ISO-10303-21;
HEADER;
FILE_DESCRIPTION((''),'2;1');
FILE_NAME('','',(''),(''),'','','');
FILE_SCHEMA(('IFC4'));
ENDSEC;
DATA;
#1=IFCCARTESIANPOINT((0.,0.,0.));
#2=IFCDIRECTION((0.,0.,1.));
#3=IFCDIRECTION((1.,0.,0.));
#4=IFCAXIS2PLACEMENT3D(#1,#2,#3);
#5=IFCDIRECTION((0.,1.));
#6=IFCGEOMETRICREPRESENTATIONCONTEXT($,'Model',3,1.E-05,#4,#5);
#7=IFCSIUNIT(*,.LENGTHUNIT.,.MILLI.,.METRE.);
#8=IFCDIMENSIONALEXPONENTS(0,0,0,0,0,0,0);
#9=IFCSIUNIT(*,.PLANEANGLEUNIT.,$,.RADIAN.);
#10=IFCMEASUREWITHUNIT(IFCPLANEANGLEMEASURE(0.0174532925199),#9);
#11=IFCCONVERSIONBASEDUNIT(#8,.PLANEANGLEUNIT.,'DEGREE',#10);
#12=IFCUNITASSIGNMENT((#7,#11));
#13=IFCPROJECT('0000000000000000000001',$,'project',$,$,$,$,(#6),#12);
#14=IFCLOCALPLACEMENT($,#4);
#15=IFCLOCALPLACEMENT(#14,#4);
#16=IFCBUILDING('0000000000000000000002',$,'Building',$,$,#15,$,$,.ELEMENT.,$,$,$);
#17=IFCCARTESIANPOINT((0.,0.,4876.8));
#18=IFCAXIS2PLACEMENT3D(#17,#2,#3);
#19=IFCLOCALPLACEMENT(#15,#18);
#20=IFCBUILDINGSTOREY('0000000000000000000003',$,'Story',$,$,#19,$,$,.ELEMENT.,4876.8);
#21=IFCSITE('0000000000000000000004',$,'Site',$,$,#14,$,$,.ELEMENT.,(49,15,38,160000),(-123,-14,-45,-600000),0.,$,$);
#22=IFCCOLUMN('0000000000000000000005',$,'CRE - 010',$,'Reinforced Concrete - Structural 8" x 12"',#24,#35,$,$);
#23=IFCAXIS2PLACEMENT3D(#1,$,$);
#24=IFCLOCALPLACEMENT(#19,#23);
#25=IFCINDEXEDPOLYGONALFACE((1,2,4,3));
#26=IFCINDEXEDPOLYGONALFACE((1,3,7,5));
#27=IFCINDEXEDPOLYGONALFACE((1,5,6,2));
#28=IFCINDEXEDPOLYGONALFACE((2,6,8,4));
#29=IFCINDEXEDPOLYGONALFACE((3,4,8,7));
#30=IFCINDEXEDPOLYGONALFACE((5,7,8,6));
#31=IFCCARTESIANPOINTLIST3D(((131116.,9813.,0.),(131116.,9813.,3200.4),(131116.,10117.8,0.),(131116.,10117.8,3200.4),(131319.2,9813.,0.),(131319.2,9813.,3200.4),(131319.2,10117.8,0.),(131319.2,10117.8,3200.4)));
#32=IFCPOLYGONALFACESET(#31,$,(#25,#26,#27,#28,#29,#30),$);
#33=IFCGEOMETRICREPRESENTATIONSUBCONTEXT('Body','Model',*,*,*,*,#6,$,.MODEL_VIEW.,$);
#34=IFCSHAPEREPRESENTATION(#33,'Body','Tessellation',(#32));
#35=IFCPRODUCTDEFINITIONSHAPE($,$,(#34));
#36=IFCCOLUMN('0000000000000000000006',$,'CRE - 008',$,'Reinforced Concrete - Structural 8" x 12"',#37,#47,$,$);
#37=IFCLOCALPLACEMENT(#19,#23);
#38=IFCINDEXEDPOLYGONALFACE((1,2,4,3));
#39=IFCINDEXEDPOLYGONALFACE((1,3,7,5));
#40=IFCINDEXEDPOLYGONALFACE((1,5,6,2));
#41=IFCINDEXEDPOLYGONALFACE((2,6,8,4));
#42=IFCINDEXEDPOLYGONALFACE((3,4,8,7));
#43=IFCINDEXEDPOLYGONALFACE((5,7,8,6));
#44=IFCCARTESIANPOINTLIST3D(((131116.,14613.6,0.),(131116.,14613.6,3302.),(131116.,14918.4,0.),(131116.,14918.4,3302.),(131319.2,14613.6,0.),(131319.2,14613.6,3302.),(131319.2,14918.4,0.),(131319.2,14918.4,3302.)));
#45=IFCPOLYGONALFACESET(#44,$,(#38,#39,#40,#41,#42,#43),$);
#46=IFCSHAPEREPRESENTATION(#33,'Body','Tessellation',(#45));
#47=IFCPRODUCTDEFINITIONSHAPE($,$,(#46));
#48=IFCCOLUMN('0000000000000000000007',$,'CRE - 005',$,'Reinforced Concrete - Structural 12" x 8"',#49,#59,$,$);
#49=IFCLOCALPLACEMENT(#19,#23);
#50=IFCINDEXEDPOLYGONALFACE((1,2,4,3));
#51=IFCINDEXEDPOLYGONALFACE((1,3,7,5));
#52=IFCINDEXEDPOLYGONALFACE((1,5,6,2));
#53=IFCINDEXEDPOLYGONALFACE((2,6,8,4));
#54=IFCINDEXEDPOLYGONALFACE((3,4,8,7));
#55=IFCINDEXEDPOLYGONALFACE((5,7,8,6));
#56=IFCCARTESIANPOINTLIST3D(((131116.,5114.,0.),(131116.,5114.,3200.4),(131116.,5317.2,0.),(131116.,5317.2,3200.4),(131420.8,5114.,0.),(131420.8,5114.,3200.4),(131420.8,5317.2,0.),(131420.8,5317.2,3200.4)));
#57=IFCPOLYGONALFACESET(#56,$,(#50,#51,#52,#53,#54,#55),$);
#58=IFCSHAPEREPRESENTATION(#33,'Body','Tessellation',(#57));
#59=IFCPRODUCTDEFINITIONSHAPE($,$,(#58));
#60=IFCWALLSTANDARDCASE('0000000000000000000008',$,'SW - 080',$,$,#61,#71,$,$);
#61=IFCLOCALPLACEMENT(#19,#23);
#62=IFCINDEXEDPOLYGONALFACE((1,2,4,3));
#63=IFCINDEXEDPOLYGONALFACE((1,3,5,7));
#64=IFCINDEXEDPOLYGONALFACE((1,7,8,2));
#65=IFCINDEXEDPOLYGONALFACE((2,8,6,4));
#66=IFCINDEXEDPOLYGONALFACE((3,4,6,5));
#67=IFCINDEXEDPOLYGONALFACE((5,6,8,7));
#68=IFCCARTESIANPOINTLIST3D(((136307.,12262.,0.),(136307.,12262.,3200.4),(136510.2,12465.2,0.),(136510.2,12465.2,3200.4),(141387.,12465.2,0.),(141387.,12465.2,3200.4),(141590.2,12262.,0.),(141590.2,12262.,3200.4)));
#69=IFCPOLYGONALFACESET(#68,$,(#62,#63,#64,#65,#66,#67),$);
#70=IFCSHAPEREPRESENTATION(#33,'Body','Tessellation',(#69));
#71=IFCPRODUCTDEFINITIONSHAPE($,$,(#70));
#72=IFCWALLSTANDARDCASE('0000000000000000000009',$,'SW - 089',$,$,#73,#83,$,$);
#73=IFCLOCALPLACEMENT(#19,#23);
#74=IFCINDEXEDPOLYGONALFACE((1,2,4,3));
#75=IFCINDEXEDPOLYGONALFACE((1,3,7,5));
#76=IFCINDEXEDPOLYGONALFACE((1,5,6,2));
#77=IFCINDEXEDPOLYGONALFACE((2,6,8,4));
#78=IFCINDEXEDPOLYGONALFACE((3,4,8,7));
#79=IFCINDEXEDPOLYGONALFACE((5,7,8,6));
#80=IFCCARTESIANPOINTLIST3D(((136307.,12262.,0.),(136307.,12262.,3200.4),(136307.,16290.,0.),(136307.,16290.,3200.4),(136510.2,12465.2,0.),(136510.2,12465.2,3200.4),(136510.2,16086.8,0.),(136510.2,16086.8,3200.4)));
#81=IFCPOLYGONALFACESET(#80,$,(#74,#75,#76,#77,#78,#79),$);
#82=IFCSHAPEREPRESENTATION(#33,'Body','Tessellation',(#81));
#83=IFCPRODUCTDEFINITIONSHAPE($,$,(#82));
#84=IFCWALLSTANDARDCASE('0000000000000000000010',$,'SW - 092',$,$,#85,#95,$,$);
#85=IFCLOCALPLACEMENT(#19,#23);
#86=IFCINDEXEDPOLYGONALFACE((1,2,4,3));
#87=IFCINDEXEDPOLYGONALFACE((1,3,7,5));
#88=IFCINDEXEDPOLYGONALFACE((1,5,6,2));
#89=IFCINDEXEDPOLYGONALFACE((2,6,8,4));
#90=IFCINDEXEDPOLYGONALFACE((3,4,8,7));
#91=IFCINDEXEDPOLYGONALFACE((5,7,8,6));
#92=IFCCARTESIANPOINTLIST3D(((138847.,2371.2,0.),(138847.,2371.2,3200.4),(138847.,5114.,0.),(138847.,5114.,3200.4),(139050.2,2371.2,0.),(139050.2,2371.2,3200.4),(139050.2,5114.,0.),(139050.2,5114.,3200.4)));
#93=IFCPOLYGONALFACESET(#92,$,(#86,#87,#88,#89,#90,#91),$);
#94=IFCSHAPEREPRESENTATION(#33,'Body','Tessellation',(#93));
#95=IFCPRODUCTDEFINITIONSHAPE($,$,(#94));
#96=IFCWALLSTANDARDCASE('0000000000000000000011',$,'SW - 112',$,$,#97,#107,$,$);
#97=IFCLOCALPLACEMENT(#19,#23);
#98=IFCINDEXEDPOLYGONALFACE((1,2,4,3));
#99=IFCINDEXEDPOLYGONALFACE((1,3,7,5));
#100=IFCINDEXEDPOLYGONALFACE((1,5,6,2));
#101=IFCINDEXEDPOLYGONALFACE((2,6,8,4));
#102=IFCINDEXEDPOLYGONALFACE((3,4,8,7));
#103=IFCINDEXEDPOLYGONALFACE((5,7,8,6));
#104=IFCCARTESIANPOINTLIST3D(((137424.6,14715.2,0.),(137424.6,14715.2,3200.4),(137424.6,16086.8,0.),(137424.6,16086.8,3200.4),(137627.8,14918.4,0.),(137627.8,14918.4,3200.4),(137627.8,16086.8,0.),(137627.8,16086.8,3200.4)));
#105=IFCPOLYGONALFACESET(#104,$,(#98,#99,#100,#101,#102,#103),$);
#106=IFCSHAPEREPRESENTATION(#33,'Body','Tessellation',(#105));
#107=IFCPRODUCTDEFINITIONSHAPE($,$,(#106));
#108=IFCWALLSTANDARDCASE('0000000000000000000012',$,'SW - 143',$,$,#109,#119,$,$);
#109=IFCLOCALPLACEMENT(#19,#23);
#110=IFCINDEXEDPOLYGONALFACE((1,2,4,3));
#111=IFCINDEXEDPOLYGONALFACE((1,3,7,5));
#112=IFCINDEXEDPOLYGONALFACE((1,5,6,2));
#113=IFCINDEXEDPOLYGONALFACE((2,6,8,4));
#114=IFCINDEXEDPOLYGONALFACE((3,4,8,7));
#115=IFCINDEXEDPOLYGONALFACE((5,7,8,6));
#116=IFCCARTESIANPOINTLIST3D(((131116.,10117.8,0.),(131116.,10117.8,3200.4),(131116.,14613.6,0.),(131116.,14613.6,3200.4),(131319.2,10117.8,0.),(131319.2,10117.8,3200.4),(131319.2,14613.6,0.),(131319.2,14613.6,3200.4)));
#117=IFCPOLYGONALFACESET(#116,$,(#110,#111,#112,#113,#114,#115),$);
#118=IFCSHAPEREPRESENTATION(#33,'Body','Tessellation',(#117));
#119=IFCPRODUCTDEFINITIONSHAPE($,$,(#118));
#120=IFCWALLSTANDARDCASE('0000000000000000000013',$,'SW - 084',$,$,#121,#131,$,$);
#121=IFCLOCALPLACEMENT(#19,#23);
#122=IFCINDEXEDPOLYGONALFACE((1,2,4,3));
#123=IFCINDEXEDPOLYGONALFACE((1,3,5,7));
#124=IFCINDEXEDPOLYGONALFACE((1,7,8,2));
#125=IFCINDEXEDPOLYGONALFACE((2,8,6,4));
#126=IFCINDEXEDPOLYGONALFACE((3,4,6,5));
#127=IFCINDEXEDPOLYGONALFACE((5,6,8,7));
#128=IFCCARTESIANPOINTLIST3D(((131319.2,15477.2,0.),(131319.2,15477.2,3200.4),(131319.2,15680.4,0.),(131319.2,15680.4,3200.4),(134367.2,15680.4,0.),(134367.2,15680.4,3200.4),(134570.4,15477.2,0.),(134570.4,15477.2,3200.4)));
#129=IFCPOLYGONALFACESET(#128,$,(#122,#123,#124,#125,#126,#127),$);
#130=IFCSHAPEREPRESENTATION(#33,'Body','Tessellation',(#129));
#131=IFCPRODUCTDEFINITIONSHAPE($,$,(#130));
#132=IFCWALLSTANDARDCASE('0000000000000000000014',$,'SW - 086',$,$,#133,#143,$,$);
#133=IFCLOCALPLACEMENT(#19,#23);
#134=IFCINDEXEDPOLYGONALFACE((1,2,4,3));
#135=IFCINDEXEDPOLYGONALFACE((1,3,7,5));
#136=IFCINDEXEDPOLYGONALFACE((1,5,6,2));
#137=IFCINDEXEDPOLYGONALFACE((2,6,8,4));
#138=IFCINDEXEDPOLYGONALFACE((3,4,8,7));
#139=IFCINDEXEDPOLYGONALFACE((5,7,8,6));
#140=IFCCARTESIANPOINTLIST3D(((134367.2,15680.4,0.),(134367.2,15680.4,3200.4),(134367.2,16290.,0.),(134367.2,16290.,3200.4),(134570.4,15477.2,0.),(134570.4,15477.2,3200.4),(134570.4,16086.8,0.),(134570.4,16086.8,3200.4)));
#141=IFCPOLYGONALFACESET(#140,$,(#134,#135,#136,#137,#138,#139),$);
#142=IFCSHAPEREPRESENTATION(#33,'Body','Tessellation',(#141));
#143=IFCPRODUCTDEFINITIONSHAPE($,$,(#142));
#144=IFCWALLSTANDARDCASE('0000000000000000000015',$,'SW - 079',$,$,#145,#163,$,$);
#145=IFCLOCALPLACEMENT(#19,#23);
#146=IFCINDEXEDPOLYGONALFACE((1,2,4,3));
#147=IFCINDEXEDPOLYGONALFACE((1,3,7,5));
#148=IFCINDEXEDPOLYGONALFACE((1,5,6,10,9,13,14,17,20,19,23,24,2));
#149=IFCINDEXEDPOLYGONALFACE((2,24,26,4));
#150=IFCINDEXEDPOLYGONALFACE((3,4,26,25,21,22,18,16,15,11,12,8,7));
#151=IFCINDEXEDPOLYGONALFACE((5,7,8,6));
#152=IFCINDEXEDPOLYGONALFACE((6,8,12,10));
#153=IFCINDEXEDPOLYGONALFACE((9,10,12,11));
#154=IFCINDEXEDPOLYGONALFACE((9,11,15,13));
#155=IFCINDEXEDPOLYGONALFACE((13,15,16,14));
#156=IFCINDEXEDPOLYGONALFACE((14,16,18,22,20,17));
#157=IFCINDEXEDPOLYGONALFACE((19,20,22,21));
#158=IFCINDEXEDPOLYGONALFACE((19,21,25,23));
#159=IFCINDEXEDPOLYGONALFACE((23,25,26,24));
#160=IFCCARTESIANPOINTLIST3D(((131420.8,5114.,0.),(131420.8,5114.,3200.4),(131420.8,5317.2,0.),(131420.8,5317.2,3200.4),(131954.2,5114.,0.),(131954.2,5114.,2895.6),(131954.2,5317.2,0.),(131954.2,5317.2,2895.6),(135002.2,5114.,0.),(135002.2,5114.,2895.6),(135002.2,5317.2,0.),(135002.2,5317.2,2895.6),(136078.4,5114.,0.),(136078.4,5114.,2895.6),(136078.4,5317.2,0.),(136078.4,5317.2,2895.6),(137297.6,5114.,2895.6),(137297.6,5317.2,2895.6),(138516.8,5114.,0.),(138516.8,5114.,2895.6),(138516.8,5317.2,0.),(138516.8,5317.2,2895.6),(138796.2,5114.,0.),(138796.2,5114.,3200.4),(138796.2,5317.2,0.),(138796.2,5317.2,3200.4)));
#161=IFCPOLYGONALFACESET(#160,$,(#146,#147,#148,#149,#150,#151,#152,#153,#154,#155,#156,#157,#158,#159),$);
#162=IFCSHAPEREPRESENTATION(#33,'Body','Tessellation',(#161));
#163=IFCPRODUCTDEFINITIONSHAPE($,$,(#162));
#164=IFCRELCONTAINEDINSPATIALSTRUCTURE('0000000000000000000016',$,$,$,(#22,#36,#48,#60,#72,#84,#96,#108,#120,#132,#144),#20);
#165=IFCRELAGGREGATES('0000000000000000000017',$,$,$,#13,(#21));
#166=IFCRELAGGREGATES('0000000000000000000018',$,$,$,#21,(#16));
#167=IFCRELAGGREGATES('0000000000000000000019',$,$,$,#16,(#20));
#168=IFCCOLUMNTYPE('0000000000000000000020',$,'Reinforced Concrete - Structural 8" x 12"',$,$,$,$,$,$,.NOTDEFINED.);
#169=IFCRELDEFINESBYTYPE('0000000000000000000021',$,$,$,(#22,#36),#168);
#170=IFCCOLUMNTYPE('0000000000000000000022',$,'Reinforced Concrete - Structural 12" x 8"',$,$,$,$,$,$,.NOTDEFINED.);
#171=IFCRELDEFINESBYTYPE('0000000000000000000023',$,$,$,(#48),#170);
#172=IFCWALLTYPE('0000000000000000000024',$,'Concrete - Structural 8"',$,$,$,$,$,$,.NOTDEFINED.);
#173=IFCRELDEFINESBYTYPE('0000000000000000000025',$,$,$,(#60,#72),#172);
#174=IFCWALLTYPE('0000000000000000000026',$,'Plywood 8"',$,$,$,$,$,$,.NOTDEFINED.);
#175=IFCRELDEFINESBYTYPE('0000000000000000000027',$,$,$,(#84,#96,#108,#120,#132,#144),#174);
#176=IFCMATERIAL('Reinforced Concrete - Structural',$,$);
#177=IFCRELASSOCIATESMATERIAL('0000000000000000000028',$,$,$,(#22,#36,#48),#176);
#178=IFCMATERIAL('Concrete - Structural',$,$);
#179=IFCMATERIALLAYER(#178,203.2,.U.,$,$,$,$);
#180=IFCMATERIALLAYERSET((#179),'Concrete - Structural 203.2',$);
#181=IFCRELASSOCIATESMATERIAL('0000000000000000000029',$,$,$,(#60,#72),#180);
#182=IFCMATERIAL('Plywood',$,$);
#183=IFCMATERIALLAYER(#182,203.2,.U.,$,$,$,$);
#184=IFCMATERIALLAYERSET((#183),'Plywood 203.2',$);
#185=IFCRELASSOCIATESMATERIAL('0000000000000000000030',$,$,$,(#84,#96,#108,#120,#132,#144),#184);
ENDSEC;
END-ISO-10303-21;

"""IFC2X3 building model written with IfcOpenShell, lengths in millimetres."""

from ifc_helpers import new_model, entity, si_unit, converted_unit, direction, frame, origin_with_axes, origin_2d_with_axis, place, context, subcontext, project, spatial, polyline, rectangle, outline, extrude, material, layer, layer_set, layer_usage, type_object, element, save


model = new_model("IFC2X3")

# Units and contexts
model_context = context("Model", 3, precision=1e-05, world=origin_with_axes(), true_north=direction((0.0, 1.0)))
body_context = subcontext(model_context, "Body", "Model", "MODEL_VIEW")
ifc_project = project(units=[si_unit("LENGTHUNIT", "METRE", prefix="MILLI"), converted_unit("PLANEANGLEUNIT", "DEGREE", entity("IfcPlaneAngleMeasure", 0.0174532925199), si_unit("PLANEANGLEUNIT", "RADIAN"), dimensions=[0, 0, 0, 0, 0, 0, 0])], contexts=[model_context])

# Site, building, storey
site_placement = place(None, origin_with_axes())
site = spatial("IfcSite", under=ifc_project, at=site_placement, Name="Site", CompositionType="ELEMENT", RefLatitude=(49, 15, 38, 160000), RefLongitude=(-123, -14, -45, -600000), RefElevation=0.0)
building_placement = place(site_placement, origin_with_axes())
building = spatial("IfcBuilding", under=site, at=building_placement, Name="Building", CompositionType="ELEMENT")
storey_placement = place(building_placement, frame((0.0, 0.0, 4876.8), z_axis=(0.0, 0.0, 1.0), x_axis=(1.0, 0.0, 0.0)))
storey = spatial("IfcBuildingStorey", under=building, at=storey_placement, Name="Story", CompositionType="ELEMENT", Elevation=4876.8)

# Columns
ifc_material_1 = material(Name="Reinforced Concrete - Structural")
column_type_1 = type_object("IfcColumnType", Name="Reinforced Concrete - Structural 8\" x 12\"", PredefinedType="NOTDEFINED")
column_1_placement = place(storey_placement, frame((131217.6, 9965.4, 0.0), z_axis=(0.0, 0.0, 1.0), x_axis=(1.0, 0.0, 0.0)))
element("IfcColumn", 1, at=column_1_placement, inside=storey, type_object=column_type_1, material=ifc_material_1, Name="CRE - 010", ObjectType="Reinforced Concrete - Structural 8\" x 12\"", context=body_context, shape_type="SweptSolid", body=[
    extrude(rectangle(XDim=203.2, YDim=304.8, at=origin_2d_with_axis()), origin_with_axes(), (0.0, 0.0, 1.0), 3200.4),
])
column_2_placement = place(storey_placement, frame((131217.6, 14766.0, 0.0), z_axis=(0.0, 0.0, 1.0), x_axis=(1.0, 0.0, 0.0)))
element("IfcColumn", 2, at=column_2_placement, inside=storey, type_object=column_type_1, material=ifc_material_1, Name="CRE - 008", ObjectType="Reinforced Concrete - Structural 8\" x 12\"", context=body_context, shape_type="SweptSolid", body=[
    extrude(rectangle(XDim=203.2, YDim=304.8, at=origin_2d_with_axis()), origin_with_axes(), (0.0, 0.0, 1.0), 3302.0),
])
column_type_2 = type_object("IfcColumnType", Name="Reinforced Concrete - Structural 12\" x 8\"", PredefinedType="NOTDEFINED")
column_3_placement = place(storey_placement, frame((131268.4, 5215.6, 0.0), z_axis=(0.0, 0.0, 1.0), x_axis=(1.0, 0.0, 0.0)))
element("IfcColumn", 3, at=column_3_placement, inside=storey, type_object=column_type_2, material=ifc_material_1, Name="CRE - 005", ObjectType="Reinforced Concrete - Structural 12\" x 8\"", context=body_context, shape_type="SweptSolid", body=[
    extrude(rectangle(XDim=304.8, YDim=203.2, at=origin_2d_with_axis()), origin_with_axes(), (0.0, 0.0, 1.0), 3200.4),
])

# Walls
ifc_material_2 = material(Name="Concrete - Structural")
ifc_layer_1 = layer(ifc_material_2, 203.2, ventilated="UNKNOWN")
ifc_layer_set_1 = layer_set([ifc_layer_1], Name="Concrete - Structural 203.2")
ifc_layer_usage_1 = layer_usage(ifc_layer_set_1, "AXIS2", "NEGATIVE", 0.0)
wall_type_1 = type_object("IfcWallType", Name="Concrete - Structural 8\"", PredefinedType="NOTDEFINED")
wall_1_placement = place(storey_placement, frame((136510.2, 12465.2, 0.0), z_axis=(0.0, 0.0, 1.0), x_axis=(1.0, 0.0, 0.0)))
element("IfcWallStandardCase", 4, at=wall_1_placement, inside=storey, type_object=wall_type_1, material=ifc_layer_usage_1, Name="SW - 080", context=body_context, shape_type="SweptSolid", body=[
    extrude(outline(polyline([(-203.2, -203.2), (5080.0, -203.2), (4876.8, 0.0), (0.0, 0.0), (-203.2, -203.2)])), origin_with_axes(), (0.0, 0.0, 1.0), 3200.4),
])
ifc_layer_usage_2 = layer_usage(ifc_layer_set_1, "AXIS2", "POSITIVE", 0.0)
wall_2_placement = place(storey_placement, frame((136510.2, 12465.2, 0.0), z_axis=(0.0, 0.0, 1.0), x_axis=(0.0, 1.0, 0.0)))
element("IfcWallStandardCase", 5, at=wall_2_placement, inside=storey, type_object=wall_type_1, material=ifc_layer_usage_2, Name="SW - 089", context=body_context, shape_type="SweptSolid", body=[
    extrude(outline(polyline([(0.0, 0.0), (3621.6, 0.0), (3824.8, 203.2), (-203.2, 203.2), (0.0, 0.0)])), origin_with_axes(), (0.0, 0.0, 1.0), 3200.4),
])

# Shared definitions
ifc_material_3 = material(Name="Plywood")
ifc_layer_2 = layer(ifc_material_3, 203.2, ventilated="UNKNOWN")
ifc_layer_set_2 = layer_set([ifc_layer_2], Name="Plywood 203.2")
wall_type_2 = type_object("IfcWallType", Name="Plywood 8\"", PredefinedType="NOTDEFINED")

# Walls
ifc_layer_usage_3 = layer_usage(ifc_layer_set_2, "AXIS2", "NEGATIVE", 0.0)
wall_3_placement = place(storey_placement, frame((138847.0, 2371.2, 0.0), z_axis=(0.0, 0.0, 1.0), x_axis=(0.0, 1.0, 0.0)))
element("IfcWallStandardCase", 6, at=wall_3_placement, inside=storey, type_object=wall_type_2, material=ifc_layer_usage_3, Name="SW - 092", context=body_context, shape_type="SweptSolid", body=[
    extrude(outline(polyline([(0.0, -203.2), (2742.9, -203.2), (2742.9, 0.0), (0.0, 0.0), (0.0, -203.2)])), origin_with_axes(), (0.0, 0.0, 1.0), 3200.4),
])
ifc_layer_usage_4 = layer_usage(ifc_layer_set_2, "AXIS2", "POSITIVE", 0.0)
wall_4_placement = place(storey_placement, frame((137627.8, 14918.4, 0.0), z_axis=(0.0, 0.0, 1.0), x_axis=(0.0, 1.0, 0.0)))
element("IfcWallStandardCase", 7, at=wall_4_placement, inside=storey, type_object=wall_type_2, material=ifc_layer_usage_4, Name="SW - 112", context=body_context, shape_type="SweptSolid", body=[
    extrude(outline(polyline([(0.0, 0.0), (1168.4, 0.0), (1168.4, 203.2), (-203.2, 203.2), (0.0, 0.0)])), origin_with_axes(), (0.0, 0.0, 1.0), 3200.4),
])
ifc_layer_usage_5 = layer_usage(ifc_layer_set_2, "AXIS2", "POSITIVE", -203.2)
wall_5_placement = place(storey_placement, frame((131116.0, 10117.8, 0.0), z_axis=(0.0, 0.0, 1.0), x_axis=(0.0, 1.0, 0.0)))
element("IfcWallStandardCase", 8, at=wall_5_placement, inside=storey, type_object=wall_type_2, material=ifc_layer_usage_5, Name="SW - 143", context=body_context, shape_type="SweptSolid", body=[
    extrude(outline(polyline([(0.0, -203.2), (4495.8, -203.2), (4495.8, 0.0), (0.0, 0.0), (0.0, -203.2)])), origin_with_axes(), (0.0, 0.0, 1.0), 3200.4),
])
ifc_layer_usage_6 = layer_usage(ifc_layer_set_2, "AXIS2", "POSITIVE", 0.0)
wall_6_placement = place(storey_placement, frame((131116.0, 15477.2, 0.0), z_axis=(0.0, 0.0, 1.0), x_axis=(1.0, 0.0, 0.0)))
element("IfcWallStandardCase", 9, at=wall_6_placement, inside=storey, type_object=wall_type_2, material=ifc_layer_usage_6, Name="SW - 084", context=body_context, shape_type="SweptSolid", body=[
    extrude(outline(polyline([(203.2, 0.0), (3454.4, 0.0), (3251.2, 203.2), (203.2, 203.2), (203.2, 0.0)])), origin_with_axes(), (0.0, 0.0, 1.0), 3200.4),
])
ifc_layer_usage_7 = layer_usage(ifc_layer_set_2, "AXIS2", "POSITIVE", 0.0)
wall_7_placement = place(storey_placement, frame((134570.4, 15477.2, 0.0), z_axis=(0.0, 0.0, 1.0), x_axis=(0.0, 1.0, 0.0)))
element("IfcWallStandardCase", 10, at=wall_7_placement, inside=storey, type_object=wall_type_2, material=ifc_layer_usage_7, Name="SW - 086", context=body_context, shape_type="SweptSolid", body=[
    extrude(outline(polyline([(0.0, 0.0), (609.6, 0.0), (812.8, 203.2), (203.2, 203.2), (0.0, 0.0)])), origin_with_axes(), (0.0, 0.0, 1.0), 3200.4),
])

# Wall, openings
ifc_layer_usage_8 = layer_usage(ifc_layer_set_2, "AXIS2", "NEGATIVE", 0.0)
wall_8_placement = place(storey_placement, frame((131420.8, 5317.2, 0.0), z_axis=(0.0, 0.0, 1.0), x_axis=(1.0, 0.0, 0.0)))
wall_8 = element("IfcWallStandardCase", 11, at=wall_8_placement, inside=storey, type_object=wall_type_2, material=ifc_layer_usage_8, Name="SW - 079", context=body_context, shape_type="SweptSolid", body=[
    extrude(outline(polyline([(0.0, -203.2), (7375.4, -203.2), (7375.4, 0.0), (0.0, 0.0), (0.0, -203.2)])), origin_with_axes(), (0.0, 0.0, 1.0), 3200.4),
])
opening_1_placement = place(wall_8_placement, frame((5267.2, 0.0, 0.0), z_axis=(0.0, 0.0, 1.0), x_axis=(1.0, 0.0, 0.0)))
element("IfcOpeningElement", 12, at=opening_1_placement, cuts=wall_8, context=body_context, shape_type="SweptSolid", body=[
    extrude(rectangle(XDim=1219.2, YDim=2895.6, at=origin_2d_with_axis()), frame((0.0, 203.2, 1447.8), z_axis=(0.0, 1.0, 0.0), x_axis=(1.0, 0.0, 0.0)), (0.0, 0.0, -1.0), 609.6),
])
opening_2_placement = place(wall_8_placement, frame((6486.4, 0.0, 0.0), z_axis=(0.0, 0.0, 1.0), x_axis=(1.0, 0.0, 0.0)))
element("IfcOpeningElement", 13, at=opening_2_placement, cuts=wall_8, context=body_context, shape_type="SweptSolid", body=[
    extrude(rectangle(XDim=1219.2, YDim=2895.6, at=origin_2d_with_axis()), frame((0.0, 203.2, 1447.8), z_axis=(0.0, -1.0, 0.0), x_axis=(-1.0, 0.0, 0.0)), (0.0, 0.0, 1.0), 609.6),
])
opening_3_placement = place(wall_8_placement, frame((2057.4, 0.0, 0.0), z_axis=(0.0, 0.0, 1.0), x_axis=(1.0, 0.0, 0.0)))
element("IfcOpeningElement", 14, at=opening_3_placement, cuts=wall_8, context=body_context, shape_type="SweptSolid", body=[
    extrude(rectangle(XDim=3048.0, YDim=2895.6, at=origin_2d_with_axis()), frame((0.0, 203.2, 1447.8), z_axis=(0.0, -1.0, 0.0), x_axis=(-1.0, 0.0, 0.0)), (0.0, 0.0, 1.0), 609.6),
])

save(model, "model.ifc")
